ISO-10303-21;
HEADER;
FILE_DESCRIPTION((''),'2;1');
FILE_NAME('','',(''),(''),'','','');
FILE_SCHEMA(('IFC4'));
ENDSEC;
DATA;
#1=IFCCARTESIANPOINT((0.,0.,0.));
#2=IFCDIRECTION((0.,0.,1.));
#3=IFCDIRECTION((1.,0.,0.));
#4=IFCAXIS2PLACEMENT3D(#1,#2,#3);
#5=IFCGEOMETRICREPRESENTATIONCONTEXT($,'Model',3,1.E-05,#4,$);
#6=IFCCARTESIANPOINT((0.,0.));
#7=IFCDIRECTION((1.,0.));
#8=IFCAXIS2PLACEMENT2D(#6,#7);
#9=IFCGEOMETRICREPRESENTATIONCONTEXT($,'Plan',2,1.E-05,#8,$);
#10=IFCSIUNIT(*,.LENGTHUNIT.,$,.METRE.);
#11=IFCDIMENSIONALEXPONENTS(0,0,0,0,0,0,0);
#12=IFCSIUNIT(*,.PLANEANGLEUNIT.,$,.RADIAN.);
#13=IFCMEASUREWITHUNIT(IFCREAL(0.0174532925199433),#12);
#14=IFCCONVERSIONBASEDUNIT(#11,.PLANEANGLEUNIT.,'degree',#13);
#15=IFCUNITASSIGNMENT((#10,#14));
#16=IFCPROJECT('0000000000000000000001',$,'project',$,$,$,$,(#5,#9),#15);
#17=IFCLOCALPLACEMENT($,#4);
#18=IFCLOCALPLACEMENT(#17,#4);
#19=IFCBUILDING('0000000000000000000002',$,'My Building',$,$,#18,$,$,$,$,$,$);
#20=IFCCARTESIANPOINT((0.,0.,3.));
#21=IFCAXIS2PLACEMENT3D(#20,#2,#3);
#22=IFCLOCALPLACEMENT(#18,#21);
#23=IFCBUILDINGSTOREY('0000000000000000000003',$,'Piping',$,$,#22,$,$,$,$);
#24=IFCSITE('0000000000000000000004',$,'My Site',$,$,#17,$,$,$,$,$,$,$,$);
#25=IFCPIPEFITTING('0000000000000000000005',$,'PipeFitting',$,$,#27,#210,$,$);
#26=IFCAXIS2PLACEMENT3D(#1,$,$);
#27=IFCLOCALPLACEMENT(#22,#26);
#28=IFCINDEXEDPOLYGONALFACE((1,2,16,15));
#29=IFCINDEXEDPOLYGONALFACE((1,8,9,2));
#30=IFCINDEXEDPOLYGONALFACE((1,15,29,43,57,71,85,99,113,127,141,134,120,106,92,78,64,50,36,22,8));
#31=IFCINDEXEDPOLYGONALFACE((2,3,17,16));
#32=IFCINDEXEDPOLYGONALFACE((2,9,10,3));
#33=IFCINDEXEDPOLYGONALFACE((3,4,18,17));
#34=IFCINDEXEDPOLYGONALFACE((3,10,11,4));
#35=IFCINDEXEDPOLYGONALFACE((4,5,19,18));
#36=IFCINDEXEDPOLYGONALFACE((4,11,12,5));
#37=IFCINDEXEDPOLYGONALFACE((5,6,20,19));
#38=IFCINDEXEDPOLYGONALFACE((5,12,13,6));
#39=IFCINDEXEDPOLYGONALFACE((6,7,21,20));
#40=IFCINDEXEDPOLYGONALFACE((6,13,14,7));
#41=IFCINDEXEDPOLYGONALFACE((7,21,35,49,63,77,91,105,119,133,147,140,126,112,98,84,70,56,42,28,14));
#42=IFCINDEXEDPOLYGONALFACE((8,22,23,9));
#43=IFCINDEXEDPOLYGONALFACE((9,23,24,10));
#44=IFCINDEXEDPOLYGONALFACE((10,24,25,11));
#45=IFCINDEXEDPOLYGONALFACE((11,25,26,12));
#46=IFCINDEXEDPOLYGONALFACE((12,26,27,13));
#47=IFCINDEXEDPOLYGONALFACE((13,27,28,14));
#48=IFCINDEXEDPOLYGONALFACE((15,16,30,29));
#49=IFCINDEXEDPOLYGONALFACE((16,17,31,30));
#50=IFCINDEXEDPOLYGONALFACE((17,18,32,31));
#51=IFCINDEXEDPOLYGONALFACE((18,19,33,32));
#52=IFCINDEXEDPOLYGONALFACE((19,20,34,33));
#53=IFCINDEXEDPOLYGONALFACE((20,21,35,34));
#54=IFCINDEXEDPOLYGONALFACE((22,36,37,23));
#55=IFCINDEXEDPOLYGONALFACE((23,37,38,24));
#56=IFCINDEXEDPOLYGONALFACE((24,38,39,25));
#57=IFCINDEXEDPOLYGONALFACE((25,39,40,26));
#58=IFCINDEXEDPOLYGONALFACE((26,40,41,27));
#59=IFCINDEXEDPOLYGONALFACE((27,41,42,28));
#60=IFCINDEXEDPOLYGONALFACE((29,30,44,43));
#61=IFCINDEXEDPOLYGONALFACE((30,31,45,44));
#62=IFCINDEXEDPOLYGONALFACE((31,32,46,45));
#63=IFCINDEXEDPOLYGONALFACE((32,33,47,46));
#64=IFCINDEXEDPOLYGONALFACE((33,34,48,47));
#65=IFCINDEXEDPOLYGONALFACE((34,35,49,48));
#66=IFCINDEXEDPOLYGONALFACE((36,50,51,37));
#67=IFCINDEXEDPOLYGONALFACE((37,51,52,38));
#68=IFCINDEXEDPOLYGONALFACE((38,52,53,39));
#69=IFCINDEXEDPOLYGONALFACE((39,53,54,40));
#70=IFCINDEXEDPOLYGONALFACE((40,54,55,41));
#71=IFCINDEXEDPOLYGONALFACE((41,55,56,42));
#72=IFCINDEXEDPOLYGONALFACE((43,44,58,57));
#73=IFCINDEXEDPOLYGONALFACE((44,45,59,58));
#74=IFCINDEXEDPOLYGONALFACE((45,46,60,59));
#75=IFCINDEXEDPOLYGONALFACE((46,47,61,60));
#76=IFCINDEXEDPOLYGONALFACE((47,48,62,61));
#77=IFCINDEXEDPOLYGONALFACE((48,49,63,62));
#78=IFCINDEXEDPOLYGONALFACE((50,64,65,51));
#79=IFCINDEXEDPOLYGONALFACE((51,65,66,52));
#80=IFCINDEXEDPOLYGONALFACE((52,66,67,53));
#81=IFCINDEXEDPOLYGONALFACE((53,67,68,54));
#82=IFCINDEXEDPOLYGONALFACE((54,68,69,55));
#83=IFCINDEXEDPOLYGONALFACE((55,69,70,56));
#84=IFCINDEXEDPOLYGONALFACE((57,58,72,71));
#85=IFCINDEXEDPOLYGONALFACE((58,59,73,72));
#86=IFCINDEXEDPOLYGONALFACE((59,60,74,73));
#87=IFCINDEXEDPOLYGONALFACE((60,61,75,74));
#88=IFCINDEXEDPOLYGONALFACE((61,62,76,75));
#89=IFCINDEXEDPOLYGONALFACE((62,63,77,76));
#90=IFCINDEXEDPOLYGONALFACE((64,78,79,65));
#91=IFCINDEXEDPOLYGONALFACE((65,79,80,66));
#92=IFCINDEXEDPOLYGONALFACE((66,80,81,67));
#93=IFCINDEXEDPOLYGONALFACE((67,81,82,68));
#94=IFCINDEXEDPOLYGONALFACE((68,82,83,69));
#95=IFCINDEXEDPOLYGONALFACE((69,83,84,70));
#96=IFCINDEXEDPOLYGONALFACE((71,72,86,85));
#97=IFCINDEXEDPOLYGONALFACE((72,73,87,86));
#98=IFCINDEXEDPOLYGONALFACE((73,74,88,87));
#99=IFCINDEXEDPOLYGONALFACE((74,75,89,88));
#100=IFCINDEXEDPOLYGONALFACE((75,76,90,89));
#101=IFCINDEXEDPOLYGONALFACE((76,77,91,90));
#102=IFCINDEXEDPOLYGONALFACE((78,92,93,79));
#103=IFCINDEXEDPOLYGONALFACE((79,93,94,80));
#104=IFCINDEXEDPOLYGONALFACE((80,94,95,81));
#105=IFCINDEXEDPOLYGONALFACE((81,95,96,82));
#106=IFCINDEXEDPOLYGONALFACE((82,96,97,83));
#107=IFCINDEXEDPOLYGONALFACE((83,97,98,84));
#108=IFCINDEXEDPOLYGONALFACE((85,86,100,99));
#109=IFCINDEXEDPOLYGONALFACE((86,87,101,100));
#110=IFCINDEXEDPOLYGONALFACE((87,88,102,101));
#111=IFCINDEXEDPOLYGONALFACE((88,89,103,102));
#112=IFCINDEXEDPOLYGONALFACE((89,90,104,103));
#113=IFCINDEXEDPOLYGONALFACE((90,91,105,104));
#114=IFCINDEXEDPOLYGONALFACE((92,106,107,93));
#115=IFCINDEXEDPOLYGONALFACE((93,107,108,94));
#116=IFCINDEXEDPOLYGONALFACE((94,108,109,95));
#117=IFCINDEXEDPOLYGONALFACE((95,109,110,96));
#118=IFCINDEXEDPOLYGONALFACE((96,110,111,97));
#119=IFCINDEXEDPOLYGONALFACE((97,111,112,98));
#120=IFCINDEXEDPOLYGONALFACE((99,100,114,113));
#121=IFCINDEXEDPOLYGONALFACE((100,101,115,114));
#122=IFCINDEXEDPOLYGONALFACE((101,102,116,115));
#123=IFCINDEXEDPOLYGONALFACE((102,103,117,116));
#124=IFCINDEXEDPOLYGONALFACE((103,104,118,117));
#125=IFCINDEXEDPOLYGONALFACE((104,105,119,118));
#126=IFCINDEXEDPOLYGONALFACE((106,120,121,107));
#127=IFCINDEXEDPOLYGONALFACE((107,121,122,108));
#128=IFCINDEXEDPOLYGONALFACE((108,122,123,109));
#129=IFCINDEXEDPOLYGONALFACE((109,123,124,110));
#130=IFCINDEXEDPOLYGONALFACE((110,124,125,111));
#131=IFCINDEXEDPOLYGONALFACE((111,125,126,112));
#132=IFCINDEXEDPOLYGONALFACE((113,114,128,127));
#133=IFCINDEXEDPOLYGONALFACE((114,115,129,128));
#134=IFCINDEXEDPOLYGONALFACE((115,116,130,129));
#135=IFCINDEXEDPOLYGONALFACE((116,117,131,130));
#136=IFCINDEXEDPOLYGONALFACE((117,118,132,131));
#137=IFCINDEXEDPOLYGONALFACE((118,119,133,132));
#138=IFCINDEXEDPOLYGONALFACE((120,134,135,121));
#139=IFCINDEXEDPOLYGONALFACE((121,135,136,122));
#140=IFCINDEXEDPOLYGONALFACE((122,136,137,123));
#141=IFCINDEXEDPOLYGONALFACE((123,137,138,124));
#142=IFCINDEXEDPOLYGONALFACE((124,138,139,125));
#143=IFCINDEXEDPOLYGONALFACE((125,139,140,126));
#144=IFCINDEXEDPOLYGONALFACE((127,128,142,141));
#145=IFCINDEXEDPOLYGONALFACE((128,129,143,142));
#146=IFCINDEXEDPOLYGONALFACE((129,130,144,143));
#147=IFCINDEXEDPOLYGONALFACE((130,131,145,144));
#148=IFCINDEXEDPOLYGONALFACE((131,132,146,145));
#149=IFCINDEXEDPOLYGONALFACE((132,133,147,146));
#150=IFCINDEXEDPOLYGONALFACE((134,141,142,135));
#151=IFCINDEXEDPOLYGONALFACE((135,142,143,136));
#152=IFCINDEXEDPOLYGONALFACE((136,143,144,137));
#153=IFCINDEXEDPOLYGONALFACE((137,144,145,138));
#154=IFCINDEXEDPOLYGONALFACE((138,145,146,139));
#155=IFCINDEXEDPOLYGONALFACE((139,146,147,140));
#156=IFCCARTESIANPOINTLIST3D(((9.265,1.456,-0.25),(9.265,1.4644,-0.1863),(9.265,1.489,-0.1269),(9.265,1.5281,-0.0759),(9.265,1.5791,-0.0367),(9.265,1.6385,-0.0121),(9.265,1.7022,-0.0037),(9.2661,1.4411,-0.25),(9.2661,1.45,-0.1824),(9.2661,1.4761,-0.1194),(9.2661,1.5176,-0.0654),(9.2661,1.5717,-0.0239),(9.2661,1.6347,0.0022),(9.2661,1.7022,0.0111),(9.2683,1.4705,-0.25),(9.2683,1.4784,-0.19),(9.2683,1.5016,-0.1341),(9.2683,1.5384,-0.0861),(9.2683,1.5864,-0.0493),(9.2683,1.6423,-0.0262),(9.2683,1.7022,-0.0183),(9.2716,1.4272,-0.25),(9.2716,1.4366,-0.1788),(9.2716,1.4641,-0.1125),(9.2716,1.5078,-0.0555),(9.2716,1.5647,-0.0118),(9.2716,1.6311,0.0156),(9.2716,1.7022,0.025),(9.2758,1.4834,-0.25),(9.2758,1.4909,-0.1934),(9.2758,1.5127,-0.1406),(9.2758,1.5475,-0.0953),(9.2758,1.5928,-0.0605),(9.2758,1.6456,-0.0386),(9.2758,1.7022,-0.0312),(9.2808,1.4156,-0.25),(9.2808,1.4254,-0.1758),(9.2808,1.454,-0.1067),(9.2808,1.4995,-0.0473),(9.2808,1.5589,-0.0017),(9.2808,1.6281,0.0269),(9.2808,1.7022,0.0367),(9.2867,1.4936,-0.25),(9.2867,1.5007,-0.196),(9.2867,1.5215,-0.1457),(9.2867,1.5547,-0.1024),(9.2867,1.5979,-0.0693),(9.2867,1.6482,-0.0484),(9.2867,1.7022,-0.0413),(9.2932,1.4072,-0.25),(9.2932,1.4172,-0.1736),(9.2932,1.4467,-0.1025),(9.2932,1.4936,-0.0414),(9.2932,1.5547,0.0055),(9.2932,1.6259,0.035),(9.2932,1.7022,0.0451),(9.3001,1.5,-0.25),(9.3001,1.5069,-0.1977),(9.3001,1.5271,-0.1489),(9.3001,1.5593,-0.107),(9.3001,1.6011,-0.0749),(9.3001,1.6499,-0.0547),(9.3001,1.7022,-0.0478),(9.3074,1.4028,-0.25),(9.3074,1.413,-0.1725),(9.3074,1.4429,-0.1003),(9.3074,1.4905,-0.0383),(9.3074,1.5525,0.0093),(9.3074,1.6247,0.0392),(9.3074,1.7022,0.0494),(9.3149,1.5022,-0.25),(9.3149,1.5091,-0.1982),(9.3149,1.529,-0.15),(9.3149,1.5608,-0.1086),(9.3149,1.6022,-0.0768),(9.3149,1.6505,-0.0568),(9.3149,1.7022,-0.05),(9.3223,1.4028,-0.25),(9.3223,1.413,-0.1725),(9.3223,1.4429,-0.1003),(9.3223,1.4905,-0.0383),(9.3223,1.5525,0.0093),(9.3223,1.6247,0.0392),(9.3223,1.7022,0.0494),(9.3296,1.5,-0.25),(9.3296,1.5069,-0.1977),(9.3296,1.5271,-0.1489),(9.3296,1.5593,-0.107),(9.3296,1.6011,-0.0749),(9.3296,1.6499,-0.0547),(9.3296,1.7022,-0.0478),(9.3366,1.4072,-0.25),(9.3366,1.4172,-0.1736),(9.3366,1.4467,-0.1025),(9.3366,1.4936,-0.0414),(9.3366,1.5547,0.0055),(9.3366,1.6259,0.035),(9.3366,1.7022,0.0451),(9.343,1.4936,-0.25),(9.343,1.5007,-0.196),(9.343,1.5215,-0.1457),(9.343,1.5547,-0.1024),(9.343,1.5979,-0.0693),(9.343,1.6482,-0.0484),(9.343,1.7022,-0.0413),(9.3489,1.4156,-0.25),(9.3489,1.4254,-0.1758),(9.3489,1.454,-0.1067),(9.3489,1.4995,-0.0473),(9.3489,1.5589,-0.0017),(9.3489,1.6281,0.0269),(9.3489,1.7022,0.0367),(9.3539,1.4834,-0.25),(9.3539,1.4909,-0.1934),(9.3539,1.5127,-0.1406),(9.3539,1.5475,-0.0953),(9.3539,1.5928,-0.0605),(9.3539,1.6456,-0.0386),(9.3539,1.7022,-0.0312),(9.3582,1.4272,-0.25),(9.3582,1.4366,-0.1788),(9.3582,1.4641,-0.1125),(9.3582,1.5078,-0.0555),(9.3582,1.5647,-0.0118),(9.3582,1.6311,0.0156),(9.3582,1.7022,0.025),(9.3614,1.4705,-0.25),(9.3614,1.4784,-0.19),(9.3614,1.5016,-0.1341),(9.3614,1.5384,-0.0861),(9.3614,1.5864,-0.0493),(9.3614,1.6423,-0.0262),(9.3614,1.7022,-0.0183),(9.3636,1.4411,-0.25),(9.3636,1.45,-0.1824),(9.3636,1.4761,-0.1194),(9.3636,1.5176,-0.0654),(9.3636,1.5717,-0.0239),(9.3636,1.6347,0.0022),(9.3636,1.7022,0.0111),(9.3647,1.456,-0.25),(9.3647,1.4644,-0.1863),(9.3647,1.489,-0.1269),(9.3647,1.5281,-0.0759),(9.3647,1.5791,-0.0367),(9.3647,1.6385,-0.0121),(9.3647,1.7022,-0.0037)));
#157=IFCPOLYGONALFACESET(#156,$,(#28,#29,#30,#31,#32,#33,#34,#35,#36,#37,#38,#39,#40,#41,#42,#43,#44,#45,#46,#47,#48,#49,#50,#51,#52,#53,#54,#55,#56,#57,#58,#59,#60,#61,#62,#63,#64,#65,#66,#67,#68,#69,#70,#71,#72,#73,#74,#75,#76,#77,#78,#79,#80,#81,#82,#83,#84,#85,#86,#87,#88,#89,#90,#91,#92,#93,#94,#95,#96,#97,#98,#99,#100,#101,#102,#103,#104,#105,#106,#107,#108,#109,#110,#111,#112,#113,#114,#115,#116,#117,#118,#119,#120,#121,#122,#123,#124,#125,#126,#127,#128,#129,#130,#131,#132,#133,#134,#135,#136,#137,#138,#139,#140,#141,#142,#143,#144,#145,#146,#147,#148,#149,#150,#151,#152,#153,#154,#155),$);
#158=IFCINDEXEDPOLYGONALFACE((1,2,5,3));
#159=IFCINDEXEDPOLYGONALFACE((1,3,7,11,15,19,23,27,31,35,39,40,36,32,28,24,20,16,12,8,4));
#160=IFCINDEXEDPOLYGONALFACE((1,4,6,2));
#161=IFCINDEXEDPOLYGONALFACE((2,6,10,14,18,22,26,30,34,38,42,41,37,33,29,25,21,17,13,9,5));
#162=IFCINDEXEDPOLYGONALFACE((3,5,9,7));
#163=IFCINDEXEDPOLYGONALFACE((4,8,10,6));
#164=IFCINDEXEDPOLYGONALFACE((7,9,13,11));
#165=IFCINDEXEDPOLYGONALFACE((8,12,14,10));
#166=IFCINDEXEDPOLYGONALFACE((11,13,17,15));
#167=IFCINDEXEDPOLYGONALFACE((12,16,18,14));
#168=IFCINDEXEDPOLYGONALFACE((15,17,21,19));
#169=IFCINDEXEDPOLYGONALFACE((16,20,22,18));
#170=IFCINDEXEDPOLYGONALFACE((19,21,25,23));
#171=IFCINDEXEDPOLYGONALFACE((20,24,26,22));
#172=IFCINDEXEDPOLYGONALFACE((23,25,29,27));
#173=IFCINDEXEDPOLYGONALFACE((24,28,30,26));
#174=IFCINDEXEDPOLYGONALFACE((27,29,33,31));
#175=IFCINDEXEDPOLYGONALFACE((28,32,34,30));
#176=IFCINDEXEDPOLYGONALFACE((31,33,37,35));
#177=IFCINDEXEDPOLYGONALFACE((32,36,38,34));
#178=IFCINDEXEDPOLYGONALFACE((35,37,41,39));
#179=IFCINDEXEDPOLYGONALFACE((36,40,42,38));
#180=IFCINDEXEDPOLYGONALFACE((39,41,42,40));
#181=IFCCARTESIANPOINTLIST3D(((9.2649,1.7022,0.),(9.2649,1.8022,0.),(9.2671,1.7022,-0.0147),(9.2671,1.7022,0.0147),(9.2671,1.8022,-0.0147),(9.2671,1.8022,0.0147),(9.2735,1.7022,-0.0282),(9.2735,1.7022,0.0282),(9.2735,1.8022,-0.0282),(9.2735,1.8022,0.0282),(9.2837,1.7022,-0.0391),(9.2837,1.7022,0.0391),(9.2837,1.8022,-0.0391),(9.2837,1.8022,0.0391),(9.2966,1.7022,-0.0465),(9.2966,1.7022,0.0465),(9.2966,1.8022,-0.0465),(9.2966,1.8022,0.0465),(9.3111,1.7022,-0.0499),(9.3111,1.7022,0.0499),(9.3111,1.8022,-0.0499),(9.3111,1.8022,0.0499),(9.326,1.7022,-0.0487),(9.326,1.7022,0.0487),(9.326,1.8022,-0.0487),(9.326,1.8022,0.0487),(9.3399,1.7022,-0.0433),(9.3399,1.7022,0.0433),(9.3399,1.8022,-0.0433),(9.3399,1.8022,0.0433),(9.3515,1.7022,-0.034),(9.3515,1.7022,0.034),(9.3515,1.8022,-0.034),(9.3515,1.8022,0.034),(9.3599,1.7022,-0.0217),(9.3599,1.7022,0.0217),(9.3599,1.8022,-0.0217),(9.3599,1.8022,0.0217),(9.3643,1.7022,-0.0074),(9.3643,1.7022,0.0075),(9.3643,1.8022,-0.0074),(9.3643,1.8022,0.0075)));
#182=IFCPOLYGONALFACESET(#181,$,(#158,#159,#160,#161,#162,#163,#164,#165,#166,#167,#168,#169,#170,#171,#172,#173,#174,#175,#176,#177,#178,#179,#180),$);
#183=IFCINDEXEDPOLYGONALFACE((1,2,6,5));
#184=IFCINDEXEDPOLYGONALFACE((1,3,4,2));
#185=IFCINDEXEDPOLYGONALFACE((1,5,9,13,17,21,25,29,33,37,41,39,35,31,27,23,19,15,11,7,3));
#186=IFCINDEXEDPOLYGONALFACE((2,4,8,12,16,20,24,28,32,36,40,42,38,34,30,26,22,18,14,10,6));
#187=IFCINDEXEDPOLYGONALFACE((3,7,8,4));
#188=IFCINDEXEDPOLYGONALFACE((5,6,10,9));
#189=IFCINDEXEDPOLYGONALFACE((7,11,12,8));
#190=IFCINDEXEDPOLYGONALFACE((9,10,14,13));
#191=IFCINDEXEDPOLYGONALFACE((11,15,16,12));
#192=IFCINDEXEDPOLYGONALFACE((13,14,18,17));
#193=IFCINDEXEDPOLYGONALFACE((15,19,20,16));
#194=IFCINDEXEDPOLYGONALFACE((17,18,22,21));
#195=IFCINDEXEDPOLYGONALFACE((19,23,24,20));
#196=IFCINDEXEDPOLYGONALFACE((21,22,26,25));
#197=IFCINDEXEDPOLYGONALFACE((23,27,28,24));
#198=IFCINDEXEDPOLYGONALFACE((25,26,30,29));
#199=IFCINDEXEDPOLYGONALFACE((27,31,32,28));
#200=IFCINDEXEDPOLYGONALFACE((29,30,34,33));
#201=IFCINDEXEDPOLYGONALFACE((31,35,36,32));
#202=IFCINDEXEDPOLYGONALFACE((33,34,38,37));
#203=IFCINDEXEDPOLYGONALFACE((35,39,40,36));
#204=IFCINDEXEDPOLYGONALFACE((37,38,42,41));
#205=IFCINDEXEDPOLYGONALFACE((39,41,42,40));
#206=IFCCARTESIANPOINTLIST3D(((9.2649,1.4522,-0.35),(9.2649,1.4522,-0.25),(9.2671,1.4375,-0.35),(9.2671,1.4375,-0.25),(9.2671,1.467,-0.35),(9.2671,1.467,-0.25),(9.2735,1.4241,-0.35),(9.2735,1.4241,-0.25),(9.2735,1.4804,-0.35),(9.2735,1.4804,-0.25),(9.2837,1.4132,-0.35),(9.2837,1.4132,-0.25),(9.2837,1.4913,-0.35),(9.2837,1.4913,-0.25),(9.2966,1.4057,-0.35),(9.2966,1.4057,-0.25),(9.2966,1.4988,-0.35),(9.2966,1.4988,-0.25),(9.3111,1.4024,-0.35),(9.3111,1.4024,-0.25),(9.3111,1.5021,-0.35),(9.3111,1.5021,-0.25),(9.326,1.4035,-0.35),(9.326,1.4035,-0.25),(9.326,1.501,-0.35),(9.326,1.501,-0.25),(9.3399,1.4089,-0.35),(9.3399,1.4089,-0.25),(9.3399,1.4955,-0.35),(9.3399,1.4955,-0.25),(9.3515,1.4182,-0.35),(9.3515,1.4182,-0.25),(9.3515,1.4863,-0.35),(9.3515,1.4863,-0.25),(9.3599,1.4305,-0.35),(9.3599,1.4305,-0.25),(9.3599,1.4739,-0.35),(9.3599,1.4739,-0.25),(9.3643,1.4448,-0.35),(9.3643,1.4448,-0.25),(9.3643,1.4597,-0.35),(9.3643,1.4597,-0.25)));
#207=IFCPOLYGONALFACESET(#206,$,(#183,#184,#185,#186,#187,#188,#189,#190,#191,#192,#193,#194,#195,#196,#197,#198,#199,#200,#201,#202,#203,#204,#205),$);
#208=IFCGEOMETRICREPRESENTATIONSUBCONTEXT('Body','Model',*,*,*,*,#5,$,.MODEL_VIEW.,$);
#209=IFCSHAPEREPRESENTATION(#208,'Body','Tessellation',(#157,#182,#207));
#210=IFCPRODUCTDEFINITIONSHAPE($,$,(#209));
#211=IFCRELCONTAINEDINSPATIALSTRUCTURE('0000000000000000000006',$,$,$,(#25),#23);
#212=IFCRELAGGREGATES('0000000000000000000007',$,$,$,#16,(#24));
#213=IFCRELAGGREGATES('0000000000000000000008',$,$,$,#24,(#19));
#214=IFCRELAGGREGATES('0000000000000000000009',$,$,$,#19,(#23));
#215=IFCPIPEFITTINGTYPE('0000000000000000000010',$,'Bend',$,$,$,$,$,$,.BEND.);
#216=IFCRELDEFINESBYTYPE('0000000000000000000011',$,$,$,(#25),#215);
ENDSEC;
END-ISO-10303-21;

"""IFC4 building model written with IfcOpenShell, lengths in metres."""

from ifc_helpers import new_model, entity, si_unit, converted_unit, frame, origin_with_axes, origin_2d_with_axis, place, context, subcontext, project, spatial, circle, extrude, source, transform, mapped, type_object, type_shapes, element, save


model = new_model("IFC4")

# Units and contexts
model_context = context("Model", 3, precision=1e-05, world=origin_with_axes())
plan_context = context("Plan", 2, precision=1e-05, world=origin_2d_with_axis())
body_context = subcontext(model_context, "Body", "Model", "MODEL_VIEW")
ifc_project = project(units=[si_unit("LENGTHUNIT", "METRE"), converted_unit("PLANEANGLEUNIT", "degree", entity("IfcReal", 0.0174532925199433), si_unit("PLANEANGLEUNIT", "RADIAN"), dimensions=[0, 0, 0, 0, 0, 0, 0])], contexts=[model_context, plan_context])

# Site, building, storey
site_placement = place(None, origin_with_axes())
site = spatial("IfcSite", under=ifc_project, at=site_placement, Name="My Site")
building_placement = place(site_placement, origin_with_axes())
building = spatial("IfcBuilding", under=site, at=building_placement, Name="My Building")
storey_placement = place(building_placement, frame((0.0, 0.0, 3.0), z_axis=(0.0, 0.0, 1.0), x_axis=(1.0, 0.0, 0.0)))
storey = spatial("IfcBuildingStorey", under=building, at=storey_placement, Name="Piping")

# Pipe fitting
pipe_fitting_type = type_object("IfcPipeFittingType", Name="Bend", PredefinedType="BEND")
shared_shape = source(origin_with_axes(), body_context, "Body", "SolidModel", [
    entity("IfcSweptDiskSolid", entity("IfcIndexedPolyCurve", entity("IfcCartesianPointList3D", [[0.0, 0.0, -0.1], [0.0, -0.0732, -0.2768], [0.0, -0.25, -0.35]]), [entity("IfcArcIndex", [1, 2, 3])]), 0.05),
    extrude(circle(Radius=0.05), origin_with_axes(), (0.0, 0.0, -1.0), 0.1),
    extrude(circle(Radius=0.05), frame((0.0, -0.25, -0.35), z_axis=(0.0, -1.0, 0.0), x_axis=(1.0, 0.0, 0.0)), (0.0, 0.0, 1.0), 0.1),
])
type_shapes(pipe_fitting_type, [shared_shape])
for number, where, z_axis, x_axis, name in (
    (1, (9.3149, 1.8022, 0.0), (0.0, 1.0, 0.0), (-1.0, 0.0, 0.0), "PipeFitting"),
):
    element("IfcPipeFitting", number, at=place(storey_placement, frame(where, z_axis=z_axis, x_axis=x_axis)), inside=storey, type_object=pipe_fitting_type, Name=name, context=body_context, shape_type="MappedRepresentation", body=[
        mapped(shared_shape, transform((0.0, 0.0, 0.0), x_axis=(1.0, 0.0, 0.0), y_axis=(0.0, 1.0, 0.0), z_axis=(0.0, 0.0, 1.0), scale=1.0)),
    ])

save(model, "model.ifc")
